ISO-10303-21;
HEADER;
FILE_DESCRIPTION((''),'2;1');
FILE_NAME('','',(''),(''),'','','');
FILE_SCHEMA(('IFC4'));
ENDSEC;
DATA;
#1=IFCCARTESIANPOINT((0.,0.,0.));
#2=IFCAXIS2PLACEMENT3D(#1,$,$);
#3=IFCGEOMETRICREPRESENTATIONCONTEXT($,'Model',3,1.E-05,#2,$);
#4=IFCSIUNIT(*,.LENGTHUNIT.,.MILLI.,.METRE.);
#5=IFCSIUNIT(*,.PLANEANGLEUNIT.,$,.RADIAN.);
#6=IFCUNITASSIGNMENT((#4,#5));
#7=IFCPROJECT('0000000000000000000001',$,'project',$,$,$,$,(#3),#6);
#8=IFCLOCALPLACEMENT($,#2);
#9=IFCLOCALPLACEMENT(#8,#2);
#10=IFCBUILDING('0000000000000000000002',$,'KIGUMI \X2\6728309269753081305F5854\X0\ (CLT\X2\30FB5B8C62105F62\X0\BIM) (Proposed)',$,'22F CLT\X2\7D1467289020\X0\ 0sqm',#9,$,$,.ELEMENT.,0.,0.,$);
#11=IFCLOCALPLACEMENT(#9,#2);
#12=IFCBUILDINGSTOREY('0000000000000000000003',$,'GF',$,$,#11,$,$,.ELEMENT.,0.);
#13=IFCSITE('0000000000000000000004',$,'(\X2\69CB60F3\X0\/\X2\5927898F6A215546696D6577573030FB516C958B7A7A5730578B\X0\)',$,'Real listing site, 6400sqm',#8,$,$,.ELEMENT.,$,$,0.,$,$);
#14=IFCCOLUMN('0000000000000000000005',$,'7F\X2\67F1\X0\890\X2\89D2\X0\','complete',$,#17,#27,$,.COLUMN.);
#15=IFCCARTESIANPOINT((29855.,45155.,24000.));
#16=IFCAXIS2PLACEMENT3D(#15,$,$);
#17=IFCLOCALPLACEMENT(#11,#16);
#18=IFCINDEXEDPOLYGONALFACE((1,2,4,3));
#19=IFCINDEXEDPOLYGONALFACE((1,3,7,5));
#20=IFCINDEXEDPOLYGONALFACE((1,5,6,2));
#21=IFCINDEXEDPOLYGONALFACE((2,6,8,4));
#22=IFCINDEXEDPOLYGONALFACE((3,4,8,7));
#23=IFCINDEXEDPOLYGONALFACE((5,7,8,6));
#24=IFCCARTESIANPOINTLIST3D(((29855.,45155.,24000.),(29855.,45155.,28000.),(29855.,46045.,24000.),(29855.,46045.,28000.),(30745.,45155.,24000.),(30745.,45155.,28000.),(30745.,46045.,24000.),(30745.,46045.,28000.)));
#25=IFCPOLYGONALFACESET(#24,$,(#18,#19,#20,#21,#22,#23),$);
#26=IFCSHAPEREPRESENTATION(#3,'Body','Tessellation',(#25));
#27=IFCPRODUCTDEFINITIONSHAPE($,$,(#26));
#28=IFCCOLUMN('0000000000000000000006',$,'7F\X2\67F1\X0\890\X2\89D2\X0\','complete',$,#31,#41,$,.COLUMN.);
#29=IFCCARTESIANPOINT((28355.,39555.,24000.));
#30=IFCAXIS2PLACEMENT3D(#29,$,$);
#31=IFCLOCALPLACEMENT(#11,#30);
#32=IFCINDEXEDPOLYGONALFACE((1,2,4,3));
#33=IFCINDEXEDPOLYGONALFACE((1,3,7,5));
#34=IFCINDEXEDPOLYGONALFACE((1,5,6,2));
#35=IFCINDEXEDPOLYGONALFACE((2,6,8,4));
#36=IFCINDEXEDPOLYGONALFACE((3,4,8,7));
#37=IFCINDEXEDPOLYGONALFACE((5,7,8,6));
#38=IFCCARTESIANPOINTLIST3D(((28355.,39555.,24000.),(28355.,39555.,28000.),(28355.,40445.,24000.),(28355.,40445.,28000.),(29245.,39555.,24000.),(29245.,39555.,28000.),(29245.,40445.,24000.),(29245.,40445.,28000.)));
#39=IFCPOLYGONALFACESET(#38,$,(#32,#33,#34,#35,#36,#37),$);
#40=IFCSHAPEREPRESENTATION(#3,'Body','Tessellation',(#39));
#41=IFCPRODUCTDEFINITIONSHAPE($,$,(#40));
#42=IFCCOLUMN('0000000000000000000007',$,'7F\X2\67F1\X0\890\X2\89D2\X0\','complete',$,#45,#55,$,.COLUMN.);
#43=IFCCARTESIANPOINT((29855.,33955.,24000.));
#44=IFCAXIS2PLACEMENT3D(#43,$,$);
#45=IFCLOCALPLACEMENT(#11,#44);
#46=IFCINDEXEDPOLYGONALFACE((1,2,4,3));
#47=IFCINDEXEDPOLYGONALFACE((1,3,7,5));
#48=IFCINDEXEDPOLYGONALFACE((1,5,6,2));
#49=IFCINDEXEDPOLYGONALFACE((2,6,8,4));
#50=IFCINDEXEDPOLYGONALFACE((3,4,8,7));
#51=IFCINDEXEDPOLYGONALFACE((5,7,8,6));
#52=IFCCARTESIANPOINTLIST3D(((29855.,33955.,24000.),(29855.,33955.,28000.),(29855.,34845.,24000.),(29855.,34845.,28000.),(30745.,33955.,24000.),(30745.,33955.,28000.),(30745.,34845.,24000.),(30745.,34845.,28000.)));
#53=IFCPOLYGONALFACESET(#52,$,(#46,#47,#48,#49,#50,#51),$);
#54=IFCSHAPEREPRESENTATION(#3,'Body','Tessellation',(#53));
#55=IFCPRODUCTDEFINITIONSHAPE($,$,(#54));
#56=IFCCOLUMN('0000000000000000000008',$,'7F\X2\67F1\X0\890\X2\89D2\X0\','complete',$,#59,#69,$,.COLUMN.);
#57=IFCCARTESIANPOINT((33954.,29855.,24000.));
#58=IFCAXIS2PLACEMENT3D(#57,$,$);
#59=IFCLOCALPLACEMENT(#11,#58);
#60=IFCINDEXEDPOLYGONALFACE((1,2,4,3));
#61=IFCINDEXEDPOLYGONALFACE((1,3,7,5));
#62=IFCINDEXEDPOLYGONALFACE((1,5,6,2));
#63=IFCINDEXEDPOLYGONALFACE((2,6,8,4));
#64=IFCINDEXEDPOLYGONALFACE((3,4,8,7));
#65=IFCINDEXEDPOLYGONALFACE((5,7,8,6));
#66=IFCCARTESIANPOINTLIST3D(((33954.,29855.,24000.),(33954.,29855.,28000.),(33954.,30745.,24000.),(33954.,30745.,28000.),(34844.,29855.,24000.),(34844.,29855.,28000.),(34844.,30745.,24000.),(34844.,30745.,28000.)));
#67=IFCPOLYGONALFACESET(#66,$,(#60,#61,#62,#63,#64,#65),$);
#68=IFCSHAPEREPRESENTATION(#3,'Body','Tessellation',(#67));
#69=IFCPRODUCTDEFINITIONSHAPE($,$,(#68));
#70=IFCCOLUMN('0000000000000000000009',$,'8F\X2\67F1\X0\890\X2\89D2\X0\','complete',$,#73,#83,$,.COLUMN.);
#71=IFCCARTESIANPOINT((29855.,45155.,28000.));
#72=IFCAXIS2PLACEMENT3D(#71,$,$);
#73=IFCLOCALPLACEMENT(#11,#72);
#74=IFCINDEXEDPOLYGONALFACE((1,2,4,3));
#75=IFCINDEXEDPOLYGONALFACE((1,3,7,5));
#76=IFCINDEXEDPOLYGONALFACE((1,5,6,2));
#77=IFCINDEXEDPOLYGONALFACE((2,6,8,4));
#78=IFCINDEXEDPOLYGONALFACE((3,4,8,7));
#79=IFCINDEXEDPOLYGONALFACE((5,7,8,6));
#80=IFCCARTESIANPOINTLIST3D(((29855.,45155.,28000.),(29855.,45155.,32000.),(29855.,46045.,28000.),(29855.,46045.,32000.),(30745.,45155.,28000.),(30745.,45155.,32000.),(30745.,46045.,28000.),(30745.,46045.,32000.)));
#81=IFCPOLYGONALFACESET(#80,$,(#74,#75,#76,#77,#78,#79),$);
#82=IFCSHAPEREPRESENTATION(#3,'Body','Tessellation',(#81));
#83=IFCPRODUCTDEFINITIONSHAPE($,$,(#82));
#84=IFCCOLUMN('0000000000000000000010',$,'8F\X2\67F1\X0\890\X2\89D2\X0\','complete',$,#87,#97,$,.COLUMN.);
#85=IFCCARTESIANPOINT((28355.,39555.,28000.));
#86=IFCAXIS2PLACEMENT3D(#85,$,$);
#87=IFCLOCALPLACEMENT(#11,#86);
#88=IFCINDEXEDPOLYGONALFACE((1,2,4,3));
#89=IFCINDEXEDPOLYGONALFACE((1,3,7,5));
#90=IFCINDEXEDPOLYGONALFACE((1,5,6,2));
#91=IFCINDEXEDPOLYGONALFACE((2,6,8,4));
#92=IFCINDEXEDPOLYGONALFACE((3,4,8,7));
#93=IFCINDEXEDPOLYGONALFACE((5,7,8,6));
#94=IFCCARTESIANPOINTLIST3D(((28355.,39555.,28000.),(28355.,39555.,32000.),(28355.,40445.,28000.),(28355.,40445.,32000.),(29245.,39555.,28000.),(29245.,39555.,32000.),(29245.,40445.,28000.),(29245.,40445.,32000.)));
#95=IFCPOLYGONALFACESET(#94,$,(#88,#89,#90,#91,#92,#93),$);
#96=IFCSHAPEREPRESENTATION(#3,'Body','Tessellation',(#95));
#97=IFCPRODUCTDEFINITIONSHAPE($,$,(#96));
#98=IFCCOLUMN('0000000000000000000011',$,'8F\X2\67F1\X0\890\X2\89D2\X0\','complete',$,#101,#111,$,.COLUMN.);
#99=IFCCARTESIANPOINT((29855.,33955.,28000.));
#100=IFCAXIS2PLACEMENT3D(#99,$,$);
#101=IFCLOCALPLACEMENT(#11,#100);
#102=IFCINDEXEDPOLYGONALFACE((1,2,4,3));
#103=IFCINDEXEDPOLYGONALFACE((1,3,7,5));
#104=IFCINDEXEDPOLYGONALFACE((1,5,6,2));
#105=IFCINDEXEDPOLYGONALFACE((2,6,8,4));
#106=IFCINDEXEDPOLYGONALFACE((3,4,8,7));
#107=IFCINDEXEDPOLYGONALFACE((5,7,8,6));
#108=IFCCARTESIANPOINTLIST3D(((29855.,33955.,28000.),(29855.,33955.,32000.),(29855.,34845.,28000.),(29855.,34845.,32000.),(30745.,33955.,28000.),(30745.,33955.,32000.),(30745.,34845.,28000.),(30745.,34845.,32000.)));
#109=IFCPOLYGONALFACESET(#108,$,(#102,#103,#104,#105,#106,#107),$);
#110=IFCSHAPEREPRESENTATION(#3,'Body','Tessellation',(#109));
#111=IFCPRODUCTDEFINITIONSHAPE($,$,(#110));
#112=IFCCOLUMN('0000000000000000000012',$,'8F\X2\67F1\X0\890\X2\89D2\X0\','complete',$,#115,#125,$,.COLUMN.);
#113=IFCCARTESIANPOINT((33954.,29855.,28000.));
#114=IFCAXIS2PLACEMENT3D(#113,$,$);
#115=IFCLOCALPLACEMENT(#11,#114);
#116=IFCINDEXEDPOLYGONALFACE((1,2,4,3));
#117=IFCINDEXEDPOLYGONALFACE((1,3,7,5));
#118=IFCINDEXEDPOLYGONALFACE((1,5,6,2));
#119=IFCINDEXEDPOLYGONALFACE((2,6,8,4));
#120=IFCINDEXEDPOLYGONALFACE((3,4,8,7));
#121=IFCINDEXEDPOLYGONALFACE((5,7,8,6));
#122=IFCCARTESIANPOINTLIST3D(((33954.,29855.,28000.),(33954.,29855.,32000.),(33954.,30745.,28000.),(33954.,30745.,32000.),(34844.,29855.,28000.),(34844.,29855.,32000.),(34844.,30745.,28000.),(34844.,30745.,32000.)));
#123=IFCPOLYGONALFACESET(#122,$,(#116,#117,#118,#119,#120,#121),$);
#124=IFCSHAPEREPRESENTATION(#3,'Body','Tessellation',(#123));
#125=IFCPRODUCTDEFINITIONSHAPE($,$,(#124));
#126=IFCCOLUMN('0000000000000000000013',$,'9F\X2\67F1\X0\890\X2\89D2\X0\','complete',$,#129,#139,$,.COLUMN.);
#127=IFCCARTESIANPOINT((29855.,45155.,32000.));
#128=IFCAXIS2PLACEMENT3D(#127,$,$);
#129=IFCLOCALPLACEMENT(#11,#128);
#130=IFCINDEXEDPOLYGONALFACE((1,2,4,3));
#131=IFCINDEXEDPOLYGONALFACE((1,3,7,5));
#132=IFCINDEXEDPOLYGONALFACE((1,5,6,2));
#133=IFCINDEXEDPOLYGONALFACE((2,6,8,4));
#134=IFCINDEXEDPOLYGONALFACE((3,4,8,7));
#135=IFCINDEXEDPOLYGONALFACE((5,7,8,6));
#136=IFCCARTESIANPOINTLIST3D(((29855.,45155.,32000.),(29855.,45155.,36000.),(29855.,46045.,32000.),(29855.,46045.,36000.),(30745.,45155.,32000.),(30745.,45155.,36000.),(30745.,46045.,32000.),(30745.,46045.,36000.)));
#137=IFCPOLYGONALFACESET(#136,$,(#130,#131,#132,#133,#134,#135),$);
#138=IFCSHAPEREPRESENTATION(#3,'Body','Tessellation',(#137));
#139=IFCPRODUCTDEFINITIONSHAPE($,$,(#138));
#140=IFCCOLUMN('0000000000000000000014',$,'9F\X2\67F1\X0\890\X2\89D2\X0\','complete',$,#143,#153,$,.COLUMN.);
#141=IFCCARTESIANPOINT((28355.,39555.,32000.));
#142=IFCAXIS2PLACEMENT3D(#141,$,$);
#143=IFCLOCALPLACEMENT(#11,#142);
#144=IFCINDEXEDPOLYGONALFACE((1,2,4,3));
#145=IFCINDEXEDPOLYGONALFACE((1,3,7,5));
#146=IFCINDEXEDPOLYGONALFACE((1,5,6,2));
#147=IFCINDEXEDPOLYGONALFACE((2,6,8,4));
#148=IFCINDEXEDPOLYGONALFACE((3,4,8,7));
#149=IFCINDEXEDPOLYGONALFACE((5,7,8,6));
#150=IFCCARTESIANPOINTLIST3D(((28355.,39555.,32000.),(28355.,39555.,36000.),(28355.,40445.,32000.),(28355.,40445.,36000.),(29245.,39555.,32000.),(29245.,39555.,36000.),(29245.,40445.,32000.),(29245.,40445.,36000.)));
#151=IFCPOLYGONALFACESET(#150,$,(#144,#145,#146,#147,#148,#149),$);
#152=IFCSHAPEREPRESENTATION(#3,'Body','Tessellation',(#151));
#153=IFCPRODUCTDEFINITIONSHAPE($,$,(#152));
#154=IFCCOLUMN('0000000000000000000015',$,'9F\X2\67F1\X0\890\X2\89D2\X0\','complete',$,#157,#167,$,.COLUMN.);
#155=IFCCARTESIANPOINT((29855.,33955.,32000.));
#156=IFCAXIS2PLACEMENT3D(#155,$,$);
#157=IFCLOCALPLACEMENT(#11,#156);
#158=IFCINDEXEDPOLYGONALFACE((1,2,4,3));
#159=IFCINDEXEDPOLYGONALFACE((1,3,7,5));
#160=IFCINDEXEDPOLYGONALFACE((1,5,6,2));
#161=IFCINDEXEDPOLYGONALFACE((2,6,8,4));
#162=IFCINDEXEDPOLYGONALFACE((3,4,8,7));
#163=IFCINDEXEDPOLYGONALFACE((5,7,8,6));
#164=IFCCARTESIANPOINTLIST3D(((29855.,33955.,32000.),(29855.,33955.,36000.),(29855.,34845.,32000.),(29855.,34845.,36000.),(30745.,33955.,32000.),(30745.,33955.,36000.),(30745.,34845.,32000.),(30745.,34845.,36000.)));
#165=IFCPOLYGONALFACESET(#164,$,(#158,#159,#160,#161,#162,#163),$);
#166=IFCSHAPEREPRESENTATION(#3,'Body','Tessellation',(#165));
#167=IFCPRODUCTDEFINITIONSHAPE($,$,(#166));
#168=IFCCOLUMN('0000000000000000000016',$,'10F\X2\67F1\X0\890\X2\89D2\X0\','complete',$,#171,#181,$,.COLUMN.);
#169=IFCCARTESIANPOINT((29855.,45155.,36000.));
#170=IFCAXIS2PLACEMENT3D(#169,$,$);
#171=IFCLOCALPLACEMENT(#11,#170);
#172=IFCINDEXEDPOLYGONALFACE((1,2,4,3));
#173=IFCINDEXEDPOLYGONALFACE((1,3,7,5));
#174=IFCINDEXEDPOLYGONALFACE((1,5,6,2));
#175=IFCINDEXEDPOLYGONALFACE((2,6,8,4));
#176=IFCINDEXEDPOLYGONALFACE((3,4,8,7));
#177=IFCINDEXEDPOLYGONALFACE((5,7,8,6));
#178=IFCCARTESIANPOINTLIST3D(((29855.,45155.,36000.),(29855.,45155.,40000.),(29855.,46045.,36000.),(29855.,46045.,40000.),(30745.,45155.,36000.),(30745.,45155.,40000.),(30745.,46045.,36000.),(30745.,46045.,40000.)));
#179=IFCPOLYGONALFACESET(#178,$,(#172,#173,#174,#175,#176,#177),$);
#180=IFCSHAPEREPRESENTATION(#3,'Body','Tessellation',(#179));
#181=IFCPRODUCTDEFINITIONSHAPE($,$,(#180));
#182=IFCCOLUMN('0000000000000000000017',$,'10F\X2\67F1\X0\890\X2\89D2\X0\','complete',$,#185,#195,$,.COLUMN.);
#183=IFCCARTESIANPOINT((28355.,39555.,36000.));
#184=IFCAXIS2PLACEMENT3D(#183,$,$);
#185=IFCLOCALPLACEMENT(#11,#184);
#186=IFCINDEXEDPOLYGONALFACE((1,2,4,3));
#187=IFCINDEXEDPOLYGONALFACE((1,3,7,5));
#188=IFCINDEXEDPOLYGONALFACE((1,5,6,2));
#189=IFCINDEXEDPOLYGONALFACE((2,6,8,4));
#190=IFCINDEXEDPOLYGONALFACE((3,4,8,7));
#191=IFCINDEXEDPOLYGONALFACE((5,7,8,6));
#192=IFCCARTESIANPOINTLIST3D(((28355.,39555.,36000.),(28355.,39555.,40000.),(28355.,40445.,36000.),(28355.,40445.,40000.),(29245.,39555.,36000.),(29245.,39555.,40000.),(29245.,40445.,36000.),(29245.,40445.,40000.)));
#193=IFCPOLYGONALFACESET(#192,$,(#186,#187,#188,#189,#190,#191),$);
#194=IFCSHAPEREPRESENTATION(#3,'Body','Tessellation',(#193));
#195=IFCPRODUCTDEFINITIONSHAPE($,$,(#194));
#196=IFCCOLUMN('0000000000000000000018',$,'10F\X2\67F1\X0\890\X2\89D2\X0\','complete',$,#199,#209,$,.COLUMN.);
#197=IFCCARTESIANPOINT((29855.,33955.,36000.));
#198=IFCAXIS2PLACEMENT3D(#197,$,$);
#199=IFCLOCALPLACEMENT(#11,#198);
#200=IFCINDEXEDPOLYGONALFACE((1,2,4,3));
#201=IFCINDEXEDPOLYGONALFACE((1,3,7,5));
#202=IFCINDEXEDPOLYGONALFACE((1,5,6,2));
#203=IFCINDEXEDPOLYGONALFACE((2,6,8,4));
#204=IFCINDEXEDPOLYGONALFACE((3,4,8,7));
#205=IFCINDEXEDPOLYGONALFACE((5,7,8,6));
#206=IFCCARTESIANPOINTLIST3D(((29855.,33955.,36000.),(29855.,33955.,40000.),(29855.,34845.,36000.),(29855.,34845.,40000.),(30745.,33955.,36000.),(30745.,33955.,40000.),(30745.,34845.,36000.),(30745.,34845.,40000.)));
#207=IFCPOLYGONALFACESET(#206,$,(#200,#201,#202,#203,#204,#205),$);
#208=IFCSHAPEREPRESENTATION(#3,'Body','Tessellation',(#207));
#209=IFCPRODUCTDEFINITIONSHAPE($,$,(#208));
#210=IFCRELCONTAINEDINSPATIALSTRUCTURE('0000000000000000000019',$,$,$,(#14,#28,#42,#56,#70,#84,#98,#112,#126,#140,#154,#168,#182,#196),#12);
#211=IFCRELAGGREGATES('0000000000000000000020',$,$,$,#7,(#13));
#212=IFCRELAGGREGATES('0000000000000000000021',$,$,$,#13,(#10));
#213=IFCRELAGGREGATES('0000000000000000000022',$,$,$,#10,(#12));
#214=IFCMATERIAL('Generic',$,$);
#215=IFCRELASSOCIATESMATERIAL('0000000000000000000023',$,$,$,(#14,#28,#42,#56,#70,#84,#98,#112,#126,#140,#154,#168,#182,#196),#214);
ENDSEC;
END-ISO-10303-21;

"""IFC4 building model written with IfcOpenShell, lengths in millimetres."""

from ifc_helpers import new_model, si_unit, frame, frame_2d, origin, place, context, project, spatial, rectangle, extrude, material, element, save


model = new_model("IFC4")

# Units and contexts
model_context = context("Model", 3, precision=1e-05, world=origin())
ifc_project = project(units=[si_unit("LENGTHUNIT", "METRE", prefix="MILLI"), si_unit("PLANEANGLEUNIT", "RADIAN")], contexts=[model_context])

# Site, building, storey
site_placement = place(None, origin())
site = spatial("IfcSite", under=ifc_project, at=site_placement, Name="(構想/大規模商業敷地・公開空地型)", ObjectType="Real listing site, 6400sqm", CompositionType="ELEMENT", RefElevation=0.0)
building_placement = place(site_placement, origin())
building = spatial("IfcBuilding", under=site, at=building_placement, Name="KIGUMI 木を極めた塔 (CLT・完成形BIM) (Proposed)", ObjectType="22F CLT純木造 0sqm", CompositionType="ELEMENT", ElevationOfRefHeight=0.0, ElevationOfTerrain=0.0)
storey_placement = place(building_placement, origin())
storey = spatial("IfcBuildingStorey", under=building, at=storey_placement, Name="GF", CompositionType="ELEMENT", Elevation=0.0)

# Columns
ifc_material = material(Name="Generic")
column_1_placement = place(storey_placement, frame((29855.0, 45155.0, 24000.0)))
element("IfcColumn", 1, at=column_1_placement, inside=storey, material=ifc_material, Name="7F柱890角", Description="complete", PredefinedType="COLUMN", context=model_context, shape_type="SweptSolid", body=[
    extrude(rectangle(XDim=890.0, YDim=890.0, at=frame_2d((445.0, 445.0))), frame((29855.0, 45155.0, 24000.0)), (0.0, 0.0, 1.0), 4000.0),
])
column_2_placement = place(storey_placement, frame((28355.0, 39555.0, 24000.0)))
element("IfcColumn", 2, at=column_2_placement, inside=storey, material=ifc_material, Name="7F柱890角", Description="complete", PredefinedType="COLUMN", context=model_context, shape_type="SweptSolid", body=[
    extrude(rectangle(XDim=890.0, YDim=890.0, at=frame_2d((445.0, 445.0))), frame((28355.0, 39555.0, 24000.0)), (0.0, 0.0, 1.0), 4000.0),
])
column_3_placement = place(storey_placement, frame((29855.0, 33955.0, 24000.0)))
element("IfcColumn", 3, at=column_3_placement, inside=storey, material=ifc_material, Name="7F柱890角", Description="complete", PredefinedType="COLUMN", context=model_context, shape_type="SweptSolid", body=[
    extrude(rectangle(XDim=890.0, YDim=890.0, at=frame_2d((445.0, 445.0))), frame((29855.0, 33955.0, 24000.0)), (0.0, 0.0, 1.0), 4000.0),
])
column_4_placement = place(storey_placement, frame((33954.0, 29855.0, 24000.0)))
element("IfcColumn", 4, at=column_4_placement, inside=storey, material=ifc_material, Name="7F柱890角", Description="complete", PredefinedType="COLUMN", context=model_context, shape_type="SweptSolid", body=[
    extrude(rectangle(XDim=890.0, YDim=890.0, at=frame_2d((445.0, 445.0))), frame((33954.0, 29855.0, 24000.0)), (0.0, 0.0, 1.0), 4000.0),
])
column_5_placement = place(storey_placement, frame((29855.0, 45155.0, 28000.0)))
element("IfcColumn", 5, at=column_5_placement, inside=storey, material=ifc_material, Name="8F柱890角", Description="complete", PredefinedType="COLUMN", context=model_context, shape_type="SweptSolid", body=[
    extrude(rectangle(XDim=890.0, YDim=890.0, at=frame_2d((445.0, 445.0))), frame((29855.0, 45155.0, 28000.0)), (0.0, 0.0, 1.0), 4000.0),
])
column_6_placement = place(storey_placement, frame((28355.0, 39555.0, 28000.0)))
element("IfcColumn", 6, at=column_6_placement, inside=storey, material=ifc_material, Name="8F柱890角", Description="complete", PredefinedType="COLUMN", context=model_context, shape_type="SweptSolid", body=[
    extrude(rectangle(XDim=890.0, YDim=890.0, at=frame_2d((445.0, 445.0))), frame((28355.0, 39555.0, 28000.0)), (0.0, 0.0, 1.0), 4000.0),
])
column_7_placement = place(storey_placement, frame((29855.0, 33955.0, 28000.0)))
element("IfcColumn", 7, at=column_7_placement, inside=storey, material=ifc_material, Name="8F柱890角", Description="complete", PredefinedType="COLUMN", context=model_context, shape_type="SweptSolid", body=[
    extrude(rectangle(XDim=890.0, YDim=890.0, at=frame_2d((445.0, 445.0))), frame((29855.0, 33955.0, 28000.0)), (0.0, 0.0, 1.0), 4000.0),
])
column_8_placement = place(storey_placement, frame((33954.0, 29855.0, 28000.0)))
element("IfcColumn", 8, at=column_8_placement, inside=storey, material=ifc_material, Name="8F柱890角", Description="complete", PredefinedType="COLUMN", context=model_context, shape_type="SweptSolid", body=[
    extrude(rectangle(XDim=890.0, YDim=890.0, at=frame_2d((445.0, 445.0))), frame((33954.0, 29855.0, 28000.0)), (0.0, 0.0, 1.0), 4000.0),
])
column_9_placement = place(storey_placement, frame((29855.0, 45155.0, 32000.0)))
element("IfcColumn", 9, at=column_9_placement, inside=storey, material=ifc_material, Name="9F柱890角", Description="complete", PredefinedType="COLUMN", context=model_context, shape_type="SweptSolid", body=[
    extrude(rectangle(XDim=890.0, YDim=890.0, at=frame_2d((445.0, 445.0))), frame((29855.0, 45155.0, 32000.0)), (0.0, 0.0, 1.0), 4000.0),
])
column_10_placement = place(storey_placement, frame((28355.0, 39555.0, 32000.0)))
element("IfcColumn", 10, at=column_10_placement, inside=storey, material=ifc_material, Name="9F柱890角", Description="complete", PredefinedType="COLUMN", context=model_context, shape_type="SweptSolid", body=[
    extrude(rectangle(XDim=890.0, YDim=890.0, at=frame_2d((445.0, 445.0))), frame((28355.0, 39555.0, 32000.0)), (0.0, 0.0, 1.0), 4000.0),
])
column_11_placement = place(storey_placement, frame((29855.0, 33955.0, 32000.0)))
element("IfcColumn", 11, at=column_11_placement, inside=storey, material=ifc_material, Name="9F柱890角", Description="complete", PredefinedType="COLUMN", context=model_context, shape_type="SweptSolid", body=[
    extrude(rectangle(XDim=890.0, YDim=890.0, at=frame_2d((445.0, 445.0))), frame((29855.0, 33955.0, 32000.0)), (0.0, 0.0, 1.0), 4000.0),
])
column_12_placement = place(storey_placement, frame((29855.0, 45155.0, 36000.0)))
element("IfcColumn", 12, at=column_12_placement, inside=storey, material=ifc_material, Name="10F柱890角", Description="complete", PredefinedType="COLUMN", context=model_context, shape_type="SweptSolid", body=[
    extrude(rectangle(XDim=890.0, YDim=890.0, at=frame_2d((445.0, 445.0))), frame((29855.0, 45155.0, 36000.0)), (0.0, 0.0, 1.0), 4000.0),
])
column_13_placement = place(storey_placement, frame((28355.0, 39555.0, 36000.0)))
element("IfcColumn", 13, at=column_13_placement, inside=storey, material=ifc_material, Name="10F柱890角", Description="complete", PredefinedType="COLUMN", context=model_context, shape_type="SweptSolid", body=[
    extrude(rectangle(XDim=890.0, YDim=890.0, at=frame_2d((445.0, 445.0))), frame((28355.0, 39555.0, 36000.0)), (0.0, 0.0, 1.0), 4000.0),
])
column_14_placement = place(storey_placement, frame((29855.0, 33955.0, 36000.0)))
element("IfcColumn", 14, at=column_14_placement, inside=storey, material=ifc_material, Name="10F柱890角", Description="complete", PredefinedType="COLUMN", context=model_context, shape_type="SweptSolid", body=[
    extrude(rectangle(XDim=890.0, YDim=890.0, at=frame_2d((445.0, 445.0))), frame((29855.0, 33955.0, 36000.0)), (0.0, 0.0, 1.0), 4000.0),
])

save(model, "model.ifc")
